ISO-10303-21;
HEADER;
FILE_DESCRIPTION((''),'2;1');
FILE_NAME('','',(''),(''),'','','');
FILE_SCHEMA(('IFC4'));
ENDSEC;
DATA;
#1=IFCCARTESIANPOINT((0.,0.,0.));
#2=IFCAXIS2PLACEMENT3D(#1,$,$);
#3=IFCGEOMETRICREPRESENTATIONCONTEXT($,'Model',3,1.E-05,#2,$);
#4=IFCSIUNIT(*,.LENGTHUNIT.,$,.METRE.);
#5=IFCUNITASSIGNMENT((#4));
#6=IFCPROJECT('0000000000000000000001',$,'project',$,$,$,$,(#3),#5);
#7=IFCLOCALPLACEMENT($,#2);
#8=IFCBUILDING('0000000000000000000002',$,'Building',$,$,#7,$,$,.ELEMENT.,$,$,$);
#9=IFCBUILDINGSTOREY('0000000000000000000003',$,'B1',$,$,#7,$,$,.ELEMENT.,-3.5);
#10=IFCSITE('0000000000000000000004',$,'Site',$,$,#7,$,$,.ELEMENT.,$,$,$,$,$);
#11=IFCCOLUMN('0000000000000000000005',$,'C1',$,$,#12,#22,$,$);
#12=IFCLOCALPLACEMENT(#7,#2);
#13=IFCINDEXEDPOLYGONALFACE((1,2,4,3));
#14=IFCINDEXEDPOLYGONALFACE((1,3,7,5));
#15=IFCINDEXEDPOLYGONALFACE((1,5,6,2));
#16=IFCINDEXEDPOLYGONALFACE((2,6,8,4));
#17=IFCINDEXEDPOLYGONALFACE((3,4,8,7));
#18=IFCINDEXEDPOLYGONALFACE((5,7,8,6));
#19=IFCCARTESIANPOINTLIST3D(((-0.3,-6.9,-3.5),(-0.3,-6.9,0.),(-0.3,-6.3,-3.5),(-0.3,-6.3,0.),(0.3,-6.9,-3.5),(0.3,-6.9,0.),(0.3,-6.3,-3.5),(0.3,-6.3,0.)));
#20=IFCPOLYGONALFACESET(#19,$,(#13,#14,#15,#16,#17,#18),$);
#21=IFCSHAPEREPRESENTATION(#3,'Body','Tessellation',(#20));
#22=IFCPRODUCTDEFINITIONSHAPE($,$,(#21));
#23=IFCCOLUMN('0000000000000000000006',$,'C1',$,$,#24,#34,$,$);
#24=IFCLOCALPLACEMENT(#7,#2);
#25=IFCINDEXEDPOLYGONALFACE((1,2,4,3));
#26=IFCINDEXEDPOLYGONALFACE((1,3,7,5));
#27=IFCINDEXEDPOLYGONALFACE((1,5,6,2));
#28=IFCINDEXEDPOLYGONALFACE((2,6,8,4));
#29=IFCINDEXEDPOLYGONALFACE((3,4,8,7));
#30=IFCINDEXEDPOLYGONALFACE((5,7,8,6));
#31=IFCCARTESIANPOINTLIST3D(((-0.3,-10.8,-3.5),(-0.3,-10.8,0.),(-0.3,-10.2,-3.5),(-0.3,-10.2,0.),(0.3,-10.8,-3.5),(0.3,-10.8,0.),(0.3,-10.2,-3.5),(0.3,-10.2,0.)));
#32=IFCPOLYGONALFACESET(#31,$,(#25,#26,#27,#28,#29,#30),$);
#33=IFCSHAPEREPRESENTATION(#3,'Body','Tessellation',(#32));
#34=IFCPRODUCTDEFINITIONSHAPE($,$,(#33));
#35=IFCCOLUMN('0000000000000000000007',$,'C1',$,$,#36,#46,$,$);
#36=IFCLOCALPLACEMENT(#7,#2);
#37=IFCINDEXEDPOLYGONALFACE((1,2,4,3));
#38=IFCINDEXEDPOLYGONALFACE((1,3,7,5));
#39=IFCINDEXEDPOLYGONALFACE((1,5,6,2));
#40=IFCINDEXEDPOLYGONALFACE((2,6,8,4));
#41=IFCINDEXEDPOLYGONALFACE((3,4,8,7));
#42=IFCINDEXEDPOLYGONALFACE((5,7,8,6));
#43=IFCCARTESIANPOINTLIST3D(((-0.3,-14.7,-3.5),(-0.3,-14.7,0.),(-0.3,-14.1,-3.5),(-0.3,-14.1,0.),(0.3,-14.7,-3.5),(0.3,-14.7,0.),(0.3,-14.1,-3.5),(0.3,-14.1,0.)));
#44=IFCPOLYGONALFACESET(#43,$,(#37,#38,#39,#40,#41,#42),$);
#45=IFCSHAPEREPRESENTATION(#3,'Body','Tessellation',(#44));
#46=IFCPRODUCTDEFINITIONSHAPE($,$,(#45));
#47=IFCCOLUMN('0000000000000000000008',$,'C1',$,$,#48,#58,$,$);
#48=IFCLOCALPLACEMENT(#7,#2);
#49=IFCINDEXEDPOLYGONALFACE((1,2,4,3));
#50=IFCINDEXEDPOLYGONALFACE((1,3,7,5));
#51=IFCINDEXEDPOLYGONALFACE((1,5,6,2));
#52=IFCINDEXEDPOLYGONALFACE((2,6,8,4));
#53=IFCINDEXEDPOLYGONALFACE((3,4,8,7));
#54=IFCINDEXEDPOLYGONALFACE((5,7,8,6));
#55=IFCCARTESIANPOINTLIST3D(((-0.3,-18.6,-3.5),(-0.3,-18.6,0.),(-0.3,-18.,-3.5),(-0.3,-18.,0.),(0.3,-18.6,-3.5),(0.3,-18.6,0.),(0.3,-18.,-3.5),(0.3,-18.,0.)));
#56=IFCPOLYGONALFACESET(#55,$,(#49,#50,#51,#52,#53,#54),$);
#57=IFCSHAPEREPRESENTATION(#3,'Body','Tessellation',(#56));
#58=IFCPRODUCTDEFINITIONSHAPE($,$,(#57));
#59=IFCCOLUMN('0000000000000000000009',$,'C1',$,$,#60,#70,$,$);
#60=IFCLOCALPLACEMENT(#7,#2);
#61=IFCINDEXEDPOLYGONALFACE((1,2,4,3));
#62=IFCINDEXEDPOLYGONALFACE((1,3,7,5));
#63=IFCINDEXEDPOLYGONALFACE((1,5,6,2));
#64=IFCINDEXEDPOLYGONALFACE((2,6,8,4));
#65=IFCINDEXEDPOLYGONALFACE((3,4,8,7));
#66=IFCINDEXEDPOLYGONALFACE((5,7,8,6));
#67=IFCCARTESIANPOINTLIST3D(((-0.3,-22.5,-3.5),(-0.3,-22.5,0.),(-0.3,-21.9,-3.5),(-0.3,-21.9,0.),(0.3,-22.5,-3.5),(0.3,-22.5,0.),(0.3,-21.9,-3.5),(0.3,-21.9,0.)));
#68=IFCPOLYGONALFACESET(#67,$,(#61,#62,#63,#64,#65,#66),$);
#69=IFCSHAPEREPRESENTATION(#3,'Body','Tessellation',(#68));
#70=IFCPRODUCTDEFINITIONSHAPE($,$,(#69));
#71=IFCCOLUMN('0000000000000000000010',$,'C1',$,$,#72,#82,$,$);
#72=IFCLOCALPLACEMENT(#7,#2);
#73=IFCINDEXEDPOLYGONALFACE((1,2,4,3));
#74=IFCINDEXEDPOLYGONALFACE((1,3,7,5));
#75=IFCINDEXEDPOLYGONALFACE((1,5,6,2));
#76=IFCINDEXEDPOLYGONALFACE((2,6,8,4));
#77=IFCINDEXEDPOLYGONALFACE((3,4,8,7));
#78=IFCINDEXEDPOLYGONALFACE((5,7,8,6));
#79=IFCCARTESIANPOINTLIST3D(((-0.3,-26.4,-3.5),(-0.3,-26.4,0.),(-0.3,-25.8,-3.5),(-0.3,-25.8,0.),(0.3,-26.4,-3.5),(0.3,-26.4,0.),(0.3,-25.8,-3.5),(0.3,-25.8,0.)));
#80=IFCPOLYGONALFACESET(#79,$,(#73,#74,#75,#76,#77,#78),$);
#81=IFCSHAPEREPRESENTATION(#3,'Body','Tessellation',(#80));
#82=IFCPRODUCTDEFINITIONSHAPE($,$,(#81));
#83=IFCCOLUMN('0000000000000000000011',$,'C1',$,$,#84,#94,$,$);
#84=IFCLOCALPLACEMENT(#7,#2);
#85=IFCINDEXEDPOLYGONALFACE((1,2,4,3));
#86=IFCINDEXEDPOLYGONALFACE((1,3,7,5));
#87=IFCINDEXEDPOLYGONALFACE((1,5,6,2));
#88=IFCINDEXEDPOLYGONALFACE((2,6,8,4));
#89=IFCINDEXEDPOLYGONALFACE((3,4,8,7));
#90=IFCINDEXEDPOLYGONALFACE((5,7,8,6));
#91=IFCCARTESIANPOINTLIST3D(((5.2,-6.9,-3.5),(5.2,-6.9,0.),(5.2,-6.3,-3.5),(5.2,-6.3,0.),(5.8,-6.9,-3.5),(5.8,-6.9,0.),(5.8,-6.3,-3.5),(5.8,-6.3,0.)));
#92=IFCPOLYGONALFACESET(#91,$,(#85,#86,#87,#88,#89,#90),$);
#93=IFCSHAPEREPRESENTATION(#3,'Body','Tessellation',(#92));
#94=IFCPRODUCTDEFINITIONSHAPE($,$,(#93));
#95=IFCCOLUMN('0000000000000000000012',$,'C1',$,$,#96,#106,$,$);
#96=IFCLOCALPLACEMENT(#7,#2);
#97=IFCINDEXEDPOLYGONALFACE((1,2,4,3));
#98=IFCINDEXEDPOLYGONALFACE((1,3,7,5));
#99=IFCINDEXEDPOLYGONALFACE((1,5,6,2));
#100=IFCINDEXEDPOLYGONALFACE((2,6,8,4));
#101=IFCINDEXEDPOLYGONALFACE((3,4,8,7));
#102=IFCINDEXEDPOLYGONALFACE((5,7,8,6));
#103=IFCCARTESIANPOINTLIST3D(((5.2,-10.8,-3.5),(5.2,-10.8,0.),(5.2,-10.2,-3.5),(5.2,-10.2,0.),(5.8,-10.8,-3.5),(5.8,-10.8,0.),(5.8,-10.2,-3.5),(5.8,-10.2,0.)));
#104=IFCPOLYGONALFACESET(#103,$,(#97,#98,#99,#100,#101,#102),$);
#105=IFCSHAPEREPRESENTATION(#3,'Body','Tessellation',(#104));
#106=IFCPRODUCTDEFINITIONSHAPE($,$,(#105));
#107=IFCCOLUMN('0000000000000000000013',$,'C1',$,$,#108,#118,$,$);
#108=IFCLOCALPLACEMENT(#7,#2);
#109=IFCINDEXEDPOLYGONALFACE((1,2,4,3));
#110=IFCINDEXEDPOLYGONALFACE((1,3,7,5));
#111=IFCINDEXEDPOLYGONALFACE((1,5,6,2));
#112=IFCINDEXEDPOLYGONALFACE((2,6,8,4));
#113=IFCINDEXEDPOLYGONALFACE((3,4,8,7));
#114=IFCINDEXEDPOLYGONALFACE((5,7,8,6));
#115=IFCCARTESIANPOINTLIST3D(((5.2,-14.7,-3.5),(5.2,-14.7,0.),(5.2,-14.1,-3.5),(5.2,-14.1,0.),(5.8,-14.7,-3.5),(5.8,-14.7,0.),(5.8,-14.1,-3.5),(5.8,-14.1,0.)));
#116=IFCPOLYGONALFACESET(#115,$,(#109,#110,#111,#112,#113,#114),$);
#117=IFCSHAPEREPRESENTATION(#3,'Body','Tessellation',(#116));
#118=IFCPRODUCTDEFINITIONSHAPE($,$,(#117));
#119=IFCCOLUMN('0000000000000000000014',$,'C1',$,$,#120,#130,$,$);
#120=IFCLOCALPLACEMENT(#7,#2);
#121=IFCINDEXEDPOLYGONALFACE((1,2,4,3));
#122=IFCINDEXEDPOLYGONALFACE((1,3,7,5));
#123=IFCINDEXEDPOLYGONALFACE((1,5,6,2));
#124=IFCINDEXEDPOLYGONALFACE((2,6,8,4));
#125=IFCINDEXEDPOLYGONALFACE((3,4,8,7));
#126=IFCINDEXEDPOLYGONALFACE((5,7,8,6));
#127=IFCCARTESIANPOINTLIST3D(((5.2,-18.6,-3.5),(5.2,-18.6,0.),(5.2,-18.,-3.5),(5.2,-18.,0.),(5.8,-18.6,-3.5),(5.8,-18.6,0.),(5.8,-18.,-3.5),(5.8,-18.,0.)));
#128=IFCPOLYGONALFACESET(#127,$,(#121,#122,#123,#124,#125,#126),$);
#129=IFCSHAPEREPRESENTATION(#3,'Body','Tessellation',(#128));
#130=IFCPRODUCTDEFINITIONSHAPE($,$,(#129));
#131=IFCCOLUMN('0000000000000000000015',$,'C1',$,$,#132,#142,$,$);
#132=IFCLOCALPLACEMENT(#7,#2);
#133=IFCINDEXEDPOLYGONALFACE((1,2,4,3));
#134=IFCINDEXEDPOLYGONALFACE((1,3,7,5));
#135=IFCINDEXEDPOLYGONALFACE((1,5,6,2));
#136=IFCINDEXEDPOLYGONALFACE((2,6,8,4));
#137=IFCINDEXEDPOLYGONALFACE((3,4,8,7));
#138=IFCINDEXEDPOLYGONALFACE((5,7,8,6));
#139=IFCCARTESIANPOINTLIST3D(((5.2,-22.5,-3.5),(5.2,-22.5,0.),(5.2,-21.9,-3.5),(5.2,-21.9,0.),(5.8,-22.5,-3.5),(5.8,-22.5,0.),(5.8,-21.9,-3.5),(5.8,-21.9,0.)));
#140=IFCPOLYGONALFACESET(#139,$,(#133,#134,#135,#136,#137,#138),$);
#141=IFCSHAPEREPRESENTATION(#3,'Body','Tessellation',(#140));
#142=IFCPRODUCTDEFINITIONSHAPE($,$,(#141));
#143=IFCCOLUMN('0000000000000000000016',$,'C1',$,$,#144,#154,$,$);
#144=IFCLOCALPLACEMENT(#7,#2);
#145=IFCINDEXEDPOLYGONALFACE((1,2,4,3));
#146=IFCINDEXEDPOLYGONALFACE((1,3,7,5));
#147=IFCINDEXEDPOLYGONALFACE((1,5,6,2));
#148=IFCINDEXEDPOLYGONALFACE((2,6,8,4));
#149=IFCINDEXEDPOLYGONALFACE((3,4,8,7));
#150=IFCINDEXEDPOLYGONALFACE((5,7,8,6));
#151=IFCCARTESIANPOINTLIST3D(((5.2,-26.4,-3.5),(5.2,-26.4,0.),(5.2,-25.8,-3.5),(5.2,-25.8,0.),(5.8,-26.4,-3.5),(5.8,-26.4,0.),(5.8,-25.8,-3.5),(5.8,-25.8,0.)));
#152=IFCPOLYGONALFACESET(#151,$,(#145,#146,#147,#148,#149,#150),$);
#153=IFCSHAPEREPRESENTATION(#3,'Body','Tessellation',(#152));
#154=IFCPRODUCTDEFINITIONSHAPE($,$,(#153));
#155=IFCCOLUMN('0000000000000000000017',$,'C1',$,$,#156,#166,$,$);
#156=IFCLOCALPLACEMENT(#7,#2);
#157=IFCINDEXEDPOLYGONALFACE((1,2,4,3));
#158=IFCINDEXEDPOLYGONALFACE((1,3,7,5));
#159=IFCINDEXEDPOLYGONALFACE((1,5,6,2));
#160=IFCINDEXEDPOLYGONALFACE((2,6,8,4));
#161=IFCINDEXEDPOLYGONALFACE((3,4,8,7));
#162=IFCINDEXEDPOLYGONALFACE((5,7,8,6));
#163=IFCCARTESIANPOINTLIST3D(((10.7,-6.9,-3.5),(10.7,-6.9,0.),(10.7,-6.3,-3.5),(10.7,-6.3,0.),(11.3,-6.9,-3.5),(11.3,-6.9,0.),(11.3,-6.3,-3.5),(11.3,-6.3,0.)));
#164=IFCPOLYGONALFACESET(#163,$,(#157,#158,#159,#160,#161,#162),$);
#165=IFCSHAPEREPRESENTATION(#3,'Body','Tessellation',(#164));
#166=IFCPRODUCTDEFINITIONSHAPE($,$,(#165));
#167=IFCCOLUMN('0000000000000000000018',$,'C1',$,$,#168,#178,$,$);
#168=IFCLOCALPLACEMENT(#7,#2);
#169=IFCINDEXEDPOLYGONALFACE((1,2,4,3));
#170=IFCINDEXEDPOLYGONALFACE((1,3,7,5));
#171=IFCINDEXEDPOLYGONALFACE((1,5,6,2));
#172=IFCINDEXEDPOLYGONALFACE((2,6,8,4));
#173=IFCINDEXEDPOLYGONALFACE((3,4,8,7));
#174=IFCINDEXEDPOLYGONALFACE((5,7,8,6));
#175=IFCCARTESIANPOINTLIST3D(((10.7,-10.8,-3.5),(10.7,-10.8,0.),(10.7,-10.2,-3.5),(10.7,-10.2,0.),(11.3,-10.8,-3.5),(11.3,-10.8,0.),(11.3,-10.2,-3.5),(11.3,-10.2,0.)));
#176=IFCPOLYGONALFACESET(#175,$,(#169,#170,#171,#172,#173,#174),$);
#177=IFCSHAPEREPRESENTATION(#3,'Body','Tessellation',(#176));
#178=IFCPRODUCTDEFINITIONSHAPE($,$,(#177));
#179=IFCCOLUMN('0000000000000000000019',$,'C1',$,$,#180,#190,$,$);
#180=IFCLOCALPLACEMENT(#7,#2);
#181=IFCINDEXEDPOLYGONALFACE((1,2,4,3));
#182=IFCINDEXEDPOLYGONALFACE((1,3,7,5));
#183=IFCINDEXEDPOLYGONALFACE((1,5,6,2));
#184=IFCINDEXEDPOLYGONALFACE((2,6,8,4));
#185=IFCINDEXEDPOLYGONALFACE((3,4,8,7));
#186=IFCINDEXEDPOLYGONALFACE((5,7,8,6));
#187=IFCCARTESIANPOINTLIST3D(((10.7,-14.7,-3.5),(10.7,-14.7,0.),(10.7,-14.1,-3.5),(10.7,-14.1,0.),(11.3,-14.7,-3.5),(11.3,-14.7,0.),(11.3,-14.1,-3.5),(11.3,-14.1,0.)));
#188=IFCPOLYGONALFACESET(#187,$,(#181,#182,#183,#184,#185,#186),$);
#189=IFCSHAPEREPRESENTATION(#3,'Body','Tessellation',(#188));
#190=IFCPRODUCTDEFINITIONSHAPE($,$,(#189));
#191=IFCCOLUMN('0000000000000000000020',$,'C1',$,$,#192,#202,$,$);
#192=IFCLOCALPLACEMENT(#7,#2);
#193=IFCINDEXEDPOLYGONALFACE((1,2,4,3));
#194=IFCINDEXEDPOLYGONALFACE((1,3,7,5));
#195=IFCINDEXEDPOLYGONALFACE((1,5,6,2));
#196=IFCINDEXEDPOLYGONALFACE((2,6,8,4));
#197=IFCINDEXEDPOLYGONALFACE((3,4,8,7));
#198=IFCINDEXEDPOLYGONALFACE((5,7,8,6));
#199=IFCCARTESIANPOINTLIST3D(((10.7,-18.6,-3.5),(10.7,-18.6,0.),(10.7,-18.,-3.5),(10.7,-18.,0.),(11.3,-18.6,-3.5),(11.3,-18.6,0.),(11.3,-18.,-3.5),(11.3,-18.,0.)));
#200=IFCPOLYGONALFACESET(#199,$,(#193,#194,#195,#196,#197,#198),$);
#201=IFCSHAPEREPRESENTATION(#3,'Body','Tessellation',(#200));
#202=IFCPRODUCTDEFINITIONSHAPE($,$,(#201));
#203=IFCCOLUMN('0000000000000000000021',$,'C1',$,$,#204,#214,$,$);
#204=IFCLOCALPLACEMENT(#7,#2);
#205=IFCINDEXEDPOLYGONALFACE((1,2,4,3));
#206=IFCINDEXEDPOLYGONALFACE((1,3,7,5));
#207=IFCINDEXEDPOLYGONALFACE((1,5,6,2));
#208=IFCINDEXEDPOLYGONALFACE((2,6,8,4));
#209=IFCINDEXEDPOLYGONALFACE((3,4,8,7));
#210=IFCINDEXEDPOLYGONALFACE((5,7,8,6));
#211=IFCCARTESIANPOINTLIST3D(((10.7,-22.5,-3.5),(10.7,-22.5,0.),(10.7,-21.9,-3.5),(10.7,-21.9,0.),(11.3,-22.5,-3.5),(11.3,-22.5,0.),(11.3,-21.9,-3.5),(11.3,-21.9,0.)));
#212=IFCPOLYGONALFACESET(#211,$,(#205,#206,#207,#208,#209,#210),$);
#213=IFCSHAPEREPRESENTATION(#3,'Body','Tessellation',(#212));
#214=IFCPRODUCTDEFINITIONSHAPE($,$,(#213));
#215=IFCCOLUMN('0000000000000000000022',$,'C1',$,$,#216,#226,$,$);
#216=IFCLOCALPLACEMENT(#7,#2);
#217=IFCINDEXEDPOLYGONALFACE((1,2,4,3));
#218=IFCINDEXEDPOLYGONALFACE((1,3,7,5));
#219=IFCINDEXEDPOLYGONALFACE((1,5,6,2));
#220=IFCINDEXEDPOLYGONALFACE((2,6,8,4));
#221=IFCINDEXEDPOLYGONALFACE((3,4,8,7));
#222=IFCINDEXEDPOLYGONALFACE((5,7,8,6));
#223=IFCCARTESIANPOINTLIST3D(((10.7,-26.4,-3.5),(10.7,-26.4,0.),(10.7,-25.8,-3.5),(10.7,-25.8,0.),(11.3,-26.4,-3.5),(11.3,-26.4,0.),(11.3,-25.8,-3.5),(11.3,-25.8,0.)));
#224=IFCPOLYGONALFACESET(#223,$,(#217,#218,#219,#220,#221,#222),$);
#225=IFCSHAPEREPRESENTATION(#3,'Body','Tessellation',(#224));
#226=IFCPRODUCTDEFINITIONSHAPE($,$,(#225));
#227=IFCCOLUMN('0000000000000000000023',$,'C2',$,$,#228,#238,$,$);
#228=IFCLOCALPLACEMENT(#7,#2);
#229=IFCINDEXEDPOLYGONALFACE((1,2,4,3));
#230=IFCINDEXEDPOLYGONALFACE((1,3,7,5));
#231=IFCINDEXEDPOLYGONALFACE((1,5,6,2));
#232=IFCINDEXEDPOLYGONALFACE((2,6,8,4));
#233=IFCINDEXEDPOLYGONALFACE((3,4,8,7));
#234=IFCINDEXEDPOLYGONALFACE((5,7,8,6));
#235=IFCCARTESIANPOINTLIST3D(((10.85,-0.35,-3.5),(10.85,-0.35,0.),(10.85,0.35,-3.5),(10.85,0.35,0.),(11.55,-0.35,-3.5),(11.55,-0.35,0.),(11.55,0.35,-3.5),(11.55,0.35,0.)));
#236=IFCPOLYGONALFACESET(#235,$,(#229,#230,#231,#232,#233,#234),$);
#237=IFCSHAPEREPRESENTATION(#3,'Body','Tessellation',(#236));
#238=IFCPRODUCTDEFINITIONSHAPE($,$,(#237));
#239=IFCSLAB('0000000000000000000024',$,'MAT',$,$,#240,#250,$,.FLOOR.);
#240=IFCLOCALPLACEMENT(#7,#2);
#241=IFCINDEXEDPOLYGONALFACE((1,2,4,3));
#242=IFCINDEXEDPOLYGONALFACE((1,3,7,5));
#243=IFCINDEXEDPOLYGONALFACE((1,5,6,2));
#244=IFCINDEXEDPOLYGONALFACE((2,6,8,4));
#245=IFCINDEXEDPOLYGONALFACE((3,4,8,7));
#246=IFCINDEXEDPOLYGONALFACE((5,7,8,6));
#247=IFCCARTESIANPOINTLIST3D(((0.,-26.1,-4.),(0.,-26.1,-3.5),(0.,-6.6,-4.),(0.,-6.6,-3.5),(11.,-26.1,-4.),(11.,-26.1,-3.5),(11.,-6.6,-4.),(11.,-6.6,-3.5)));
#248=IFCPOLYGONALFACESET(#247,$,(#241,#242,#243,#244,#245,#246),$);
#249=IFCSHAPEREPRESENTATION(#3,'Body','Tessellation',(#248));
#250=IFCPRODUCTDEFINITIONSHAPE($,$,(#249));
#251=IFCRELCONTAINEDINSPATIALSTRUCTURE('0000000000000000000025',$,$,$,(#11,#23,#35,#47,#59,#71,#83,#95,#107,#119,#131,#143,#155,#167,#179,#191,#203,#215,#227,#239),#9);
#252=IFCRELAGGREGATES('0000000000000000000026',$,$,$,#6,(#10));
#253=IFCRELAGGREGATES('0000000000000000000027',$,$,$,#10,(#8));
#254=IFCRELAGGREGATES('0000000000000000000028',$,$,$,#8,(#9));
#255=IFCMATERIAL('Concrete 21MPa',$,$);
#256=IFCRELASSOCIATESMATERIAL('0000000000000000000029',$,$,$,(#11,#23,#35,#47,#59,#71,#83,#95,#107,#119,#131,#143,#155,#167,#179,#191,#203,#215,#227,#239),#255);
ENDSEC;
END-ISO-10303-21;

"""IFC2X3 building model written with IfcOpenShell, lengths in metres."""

from ifc_helpers import new_model, si_unit, frame, origin, origin_2d, place, context, project, spatial, rectangle, extrude, material, element, save


model = new_model("IFC2X3")

# Units and contexts
model_context = context("Model", 3, precision=1e-05, world=origin())
ifc_project = project(units=[si_unit("LENGTHUNIT", "METRE")], contexts=[model_context])

# Site, building, storey
placement = place(None, origin())
site = spatial("IfcSite", under=ifc_project, at=placement, Name="Site", CompositionType="ELEMENT")
building = spatial("IfcBuilding", under=site, at=placement, Name="Building", CompositionType="ELEMENT")
storey = spatial("IfcBuildingStorey", under=building, at=placement, Name="B1", CompositionType="ELEMENT", Elevation=-3.5)

# Columns
ifc_material_1 = material(Name="Concrete 21MPa")
for number, where, name in (
    (1, (0.0, -6.6, -3.5), "C1"),
    (2, (0.0, -10.5, -3.5), "C1"),
    (3, (0.0, -14.4, -3.5), "C1"),
    (4, (0.0, -18.3, -3.5), "C1"),
    (5, (0.0, -22.2, -3.5), "C1"),
    (6, (0.0, -26.1, -3.5), "C1"),
    (7, (5.5, -6.6, -3.5), "C1"),
    (8, (5.5, -10.5, -3.5), "C1"),
    (9, (5.5, -14.4, -3.5), "C1"),
    (10, (5.5, -18.3, -3.5), "C1"),
    (11, (5.5, -22.2, -3.5), "C1"),
    (12, (5.5, -26.1, -3.5), "C1"),
    (13, (11.0, -6.6, -3.5), "C1"),
    (14, (11.0, -10.5, -3.5), "C1"),
    (15, (11.0, -14.4, -3.5), "C1"),
    (16, (11.0, -18.3, -3.5), "C1"),
    (17, (11.0, -22.2, -3.5), "C1"),
    (18, (11.0, -26.1, -3.5), "C1"),
):
    element("IfcColumn", number, at=place(None, frame(where)), inside=storey, material=ifc_material_1, Name=name, context=model_context, shape_type="SweptSolid", body=[
        extrude(rectangle(XDim=0.6, YDim=0.6, at=origin_2d()), origin(), (0.0, 0.0, 1.0), 3.5),
    ])
column_placement = place(None, frame((11.2, 0.0, -3.5)))
element("IfcColumn", 19, at=column_placement, inside=storey, material=ifc_material_1, Name="C2", context=model_context, shape_type="SweptSolid", body=[
    extrude(rectangle(XDim=0.7, YDim=0.7, at=origin_2d()), origin(), (0.0, 0.0, 1.0), 3.5),
])

# Slab
slab_placement = place(None, frame((5.5, -16.35, -4.0)))
element("IfcSlab", 20, at=slab_placement, inside=storey, material=ifc_material_1, Name="MAT", PredefinedType="FLOOR", context=model_context, shape_type="SweptSolid", body=[
    extrude(rectangle(XDim=11.0, YDim=19.5, at=origin_2d()), origin(), (0.0, 0.0, 1.0), 0.5),
])

save(model, "model.ifc")
